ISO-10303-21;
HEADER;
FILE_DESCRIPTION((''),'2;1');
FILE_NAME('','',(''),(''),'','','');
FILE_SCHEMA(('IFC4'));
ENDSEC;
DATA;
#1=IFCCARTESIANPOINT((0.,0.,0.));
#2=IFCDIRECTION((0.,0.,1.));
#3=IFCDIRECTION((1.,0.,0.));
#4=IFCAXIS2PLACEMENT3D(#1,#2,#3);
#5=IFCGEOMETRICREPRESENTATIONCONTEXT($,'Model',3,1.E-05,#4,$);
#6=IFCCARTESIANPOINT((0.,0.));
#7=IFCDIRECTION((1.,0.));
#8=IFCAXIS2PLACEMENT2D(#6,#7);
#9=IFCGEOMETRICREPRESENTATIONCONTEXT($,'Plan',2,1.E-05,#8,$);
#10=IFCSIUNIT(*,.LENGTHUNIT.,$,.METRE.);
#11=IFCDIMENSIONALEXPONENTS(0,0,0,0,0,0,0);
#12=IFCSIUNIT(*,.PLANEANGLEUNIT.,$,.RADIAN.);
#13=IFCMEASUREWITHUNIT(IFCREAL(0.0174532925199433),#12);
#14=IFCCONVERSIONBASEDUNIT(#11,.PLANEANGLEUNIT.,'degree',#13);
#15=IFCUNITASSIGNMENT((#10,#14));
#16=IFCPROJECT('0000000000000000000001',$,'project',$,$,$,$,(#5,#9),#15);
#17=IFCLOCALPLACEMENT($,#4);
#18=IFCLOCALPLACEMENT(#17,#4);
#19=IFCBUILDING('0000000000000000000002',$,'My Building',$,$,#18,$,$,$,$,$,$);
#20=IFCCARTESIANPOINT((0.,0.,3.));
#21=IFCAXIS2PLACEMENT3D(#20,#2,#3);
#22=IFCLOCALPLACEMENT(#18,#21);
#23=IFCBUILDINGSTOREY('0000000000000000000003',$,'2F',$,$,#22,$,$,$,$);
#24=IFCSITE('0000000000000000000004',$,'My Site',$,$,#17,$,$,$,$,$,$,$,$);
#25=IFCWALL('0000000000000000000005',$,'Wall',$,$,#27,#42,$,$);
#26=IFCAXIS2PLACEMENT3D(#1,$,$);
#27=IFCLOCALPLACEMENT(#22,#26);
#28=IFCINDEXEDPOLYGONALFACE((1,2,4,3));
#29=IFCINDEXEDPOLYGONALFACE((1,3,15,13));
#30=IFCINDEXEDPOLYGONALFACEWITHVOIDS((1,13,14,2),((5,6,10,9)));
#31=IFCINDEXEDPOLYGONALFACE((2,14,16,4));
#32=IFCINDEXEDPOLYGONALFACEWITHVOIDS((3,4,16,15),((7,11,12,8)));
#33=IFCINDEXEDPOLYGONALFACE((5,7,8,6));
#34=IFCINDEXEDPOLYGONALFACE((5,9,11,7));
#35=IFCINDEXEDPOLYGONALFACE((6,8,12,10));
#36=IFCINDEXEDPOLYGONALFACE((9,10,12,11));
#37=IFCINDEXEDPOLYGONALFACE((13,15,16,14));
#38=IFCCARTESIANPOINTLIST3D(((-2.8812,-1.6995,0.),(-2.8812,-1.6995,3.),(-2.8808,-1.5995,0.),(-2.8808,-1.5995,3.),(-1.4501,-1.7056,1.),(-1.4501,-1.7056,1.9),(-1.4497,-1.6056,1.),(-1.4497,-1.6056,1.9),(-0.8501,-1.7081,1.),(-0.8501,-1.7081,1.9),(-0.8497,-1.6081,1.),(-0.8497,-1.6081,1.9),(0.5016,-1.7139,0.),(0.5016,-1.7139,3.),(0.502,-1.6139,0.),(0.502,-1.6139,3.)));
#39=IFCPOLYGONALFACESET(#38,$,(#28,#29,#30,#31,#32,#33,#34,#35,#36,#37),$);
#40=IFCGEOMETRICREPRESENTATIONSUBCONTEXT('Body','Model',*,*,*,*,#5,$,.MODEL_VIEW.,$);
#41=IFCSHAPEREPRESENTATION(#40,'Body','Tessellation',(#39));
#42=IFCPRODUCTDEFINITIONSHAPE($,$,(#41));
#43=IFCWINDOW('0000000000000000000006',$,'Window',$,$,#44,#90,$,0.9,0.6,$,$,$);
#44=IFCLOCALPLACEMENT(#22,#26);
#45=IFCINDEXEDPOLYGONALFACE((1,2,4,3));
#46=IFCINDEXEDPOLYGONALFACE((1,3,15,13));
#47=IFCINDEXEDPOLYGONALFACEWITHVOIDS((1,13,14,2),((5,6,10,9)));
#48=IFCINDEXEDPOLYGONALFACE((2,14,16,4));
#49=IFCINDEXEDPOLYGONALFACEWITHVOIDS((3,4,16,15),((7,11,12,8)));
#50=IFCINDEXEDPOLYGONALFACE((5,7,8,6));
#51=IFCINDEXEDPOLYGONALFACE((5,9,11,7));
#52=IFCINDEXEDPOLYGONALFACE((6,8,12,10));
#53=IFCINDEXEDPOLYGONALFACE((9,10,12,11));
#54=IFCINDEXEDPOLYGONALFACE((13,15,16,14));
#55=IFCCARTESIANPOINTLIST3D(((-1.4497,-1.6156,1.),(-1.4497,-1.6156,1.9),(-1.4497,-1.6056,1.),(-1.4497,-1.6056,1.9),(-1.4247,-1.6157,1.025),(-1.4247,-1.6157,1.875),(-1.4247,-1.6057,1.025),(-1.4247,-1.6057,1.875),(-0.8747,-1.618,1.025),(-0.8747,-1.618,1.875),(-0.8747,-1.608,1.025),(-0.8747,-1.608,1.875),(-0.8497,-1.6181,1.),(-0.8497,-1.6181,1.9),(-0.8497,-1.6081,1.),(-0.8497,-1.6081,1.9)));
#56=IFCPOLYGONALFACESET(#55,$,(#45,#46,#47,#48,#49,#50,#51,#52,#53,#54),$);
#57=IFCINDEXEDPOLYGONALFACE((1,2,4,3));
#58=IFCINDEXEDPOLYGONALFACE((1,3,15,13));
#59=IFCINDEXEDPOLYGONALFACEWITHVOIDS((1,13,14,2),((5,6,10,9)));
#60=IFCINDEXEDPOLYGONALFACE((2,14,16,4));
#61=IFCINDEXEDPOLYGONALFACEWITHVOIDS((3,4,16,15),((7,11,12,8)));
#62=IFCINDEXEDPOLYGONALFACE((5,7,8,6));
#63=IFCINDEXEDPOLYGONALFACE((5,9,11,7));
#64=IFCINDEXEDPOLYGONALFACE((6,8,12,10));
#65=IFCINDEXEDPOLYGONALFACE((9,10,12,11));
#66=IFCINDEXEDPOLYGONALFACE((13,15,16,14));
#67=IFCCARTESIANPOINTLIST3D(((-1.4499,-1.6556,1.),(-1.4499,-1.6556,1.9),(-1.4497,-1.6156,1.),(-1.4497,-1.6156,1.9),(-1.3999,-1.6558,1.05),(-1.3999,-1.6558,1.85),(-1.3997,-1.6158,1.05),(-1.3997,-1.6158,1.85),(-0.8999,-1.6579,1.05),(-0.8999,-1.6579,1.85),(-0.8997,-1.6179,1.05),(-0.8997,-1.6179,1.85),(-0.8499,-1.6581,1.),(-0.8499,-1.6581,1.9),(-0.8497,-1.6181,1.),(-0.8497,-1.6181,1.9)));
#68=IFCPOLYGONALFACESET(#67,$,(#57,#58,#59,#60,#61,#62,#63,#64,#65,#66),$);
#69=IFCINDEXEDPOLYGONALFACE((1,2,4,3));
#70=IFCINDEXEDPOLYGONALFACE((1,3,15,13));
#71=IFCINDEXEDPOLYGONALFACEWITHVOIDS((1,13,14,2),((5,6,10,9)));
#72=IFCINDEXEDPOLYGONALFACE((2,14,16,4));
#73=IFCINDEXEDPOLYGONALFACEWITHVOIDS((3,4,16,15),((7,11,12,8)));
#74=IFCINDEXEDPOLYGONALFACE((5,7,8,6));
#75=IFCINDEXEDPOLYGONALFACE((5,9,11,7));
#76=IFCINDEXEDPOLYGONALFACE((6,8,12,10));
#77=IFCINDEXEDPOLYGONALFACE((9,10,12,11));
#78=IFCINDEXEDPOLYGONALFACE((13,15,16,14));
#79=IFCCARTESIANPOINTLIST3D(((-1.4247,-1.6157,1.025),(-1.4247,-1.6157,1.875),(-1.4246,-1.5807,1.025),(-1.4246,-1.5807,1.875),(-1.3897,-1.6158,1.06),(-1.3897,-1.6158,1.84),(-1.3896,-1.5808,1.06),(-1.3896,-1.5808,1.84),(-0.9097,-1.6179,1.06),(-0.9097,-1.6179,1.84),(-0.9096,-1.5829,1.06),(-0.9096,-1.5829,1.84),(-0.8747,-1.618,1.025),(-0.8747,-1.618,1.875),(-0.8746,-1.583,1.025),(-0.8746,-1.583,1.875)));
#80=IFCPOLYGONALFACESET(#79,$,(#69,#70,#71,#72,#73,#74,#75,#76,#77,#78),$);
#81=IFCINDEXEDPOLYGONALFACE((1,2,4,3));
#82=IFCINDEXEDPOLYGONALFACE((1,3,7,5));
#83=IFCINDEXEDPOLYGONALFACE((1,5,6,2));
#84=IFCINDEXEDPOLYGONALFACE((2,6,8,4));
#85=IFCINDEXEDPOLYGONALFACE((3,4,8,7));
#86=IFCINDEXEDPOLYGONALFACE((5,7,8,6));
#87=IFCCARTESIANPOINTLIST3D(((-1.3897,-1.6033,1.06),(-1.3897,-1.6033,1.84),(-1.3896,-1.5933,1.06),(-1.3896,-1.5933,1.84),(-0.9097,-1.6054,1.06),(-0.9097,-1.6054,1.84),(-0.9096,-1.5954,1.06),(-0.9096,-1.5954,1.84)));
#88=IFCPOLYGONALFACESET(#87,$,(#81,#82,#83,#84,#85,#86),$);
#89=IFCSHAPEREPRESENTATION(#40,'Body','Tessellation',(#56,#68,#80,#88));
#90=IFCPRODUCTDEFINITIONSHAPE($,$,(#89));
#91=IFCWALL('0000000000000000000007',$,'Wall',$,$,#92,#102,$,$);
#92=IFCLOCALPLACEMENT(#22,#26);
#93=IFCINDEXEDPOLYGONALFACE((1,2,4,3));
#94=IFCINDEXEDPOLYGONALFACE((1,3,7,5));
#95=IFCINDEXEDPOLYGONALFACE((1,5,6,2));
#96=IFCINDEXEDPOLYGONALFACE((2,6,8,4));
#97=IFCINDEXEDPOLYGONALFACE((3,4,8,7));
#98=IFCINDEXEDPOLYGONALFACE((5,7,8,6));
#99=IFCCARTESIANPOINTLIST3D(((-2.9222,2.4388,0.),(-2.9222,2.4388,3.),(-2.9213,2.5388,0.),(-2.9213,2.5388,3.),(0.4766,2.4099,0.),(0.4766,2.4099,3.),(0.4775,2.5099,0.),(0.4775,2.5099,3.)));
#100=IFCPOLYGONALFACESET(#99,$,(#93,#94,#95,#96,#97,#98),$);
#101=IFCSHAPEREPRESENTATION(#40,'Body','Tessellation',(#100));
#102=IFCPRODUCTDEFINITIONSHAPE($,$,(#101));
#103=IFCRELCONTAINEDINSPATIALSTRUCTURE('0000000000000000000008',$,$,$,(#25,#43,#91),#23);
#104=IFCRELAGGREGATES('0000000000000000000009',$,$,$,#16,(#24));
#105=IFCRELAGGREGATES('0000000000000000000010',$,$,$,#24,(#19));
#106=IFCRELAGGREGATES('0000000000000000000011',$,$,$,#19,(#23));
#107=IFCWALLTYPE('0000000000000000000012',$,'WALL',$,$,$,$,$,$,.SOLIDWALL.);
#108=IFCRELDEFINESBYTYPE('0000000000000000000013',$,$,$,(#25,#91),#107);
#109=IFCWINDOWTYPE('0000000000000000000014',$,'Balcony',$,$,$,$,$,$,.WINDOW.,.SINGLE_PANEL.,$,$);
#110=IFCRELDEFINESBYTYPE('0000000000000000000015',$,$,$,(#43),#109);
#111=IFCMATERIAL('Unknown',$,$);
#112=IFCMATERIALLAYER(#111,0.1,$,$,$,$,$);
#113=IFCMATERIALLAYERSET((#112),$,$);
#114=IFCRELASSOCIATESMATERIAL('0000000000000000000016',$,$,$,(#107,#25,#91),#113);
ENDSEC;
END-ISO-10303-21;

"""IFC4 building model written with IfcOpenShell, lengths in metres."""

from ifc_helpers import new_model, entity, si_unit, converted_unit, frame, origin_with_axes, origin_2d_with_axis, place, context, subcontext, project, spatial, line, indexed_curve, outline, extrude, shape, source, transform, mapped, material, layer, layer_set, layer_usage, type_object, type_shapes, element, fill, save


model = new_model("IFC4")

# Units and contexts
model_context = context("Model", 3, precision=1e-05, world=origin_with_axes())
plan_context = context("Plan", 2, precision=1e-05, world=origin_2d_with_axis())
body_context_1 = subcontext(model_context, "Body", "Model", "MODEL_VIEW")
body_context_2 = subcontext(plan_context, "Body", "Plan", "PLAN_VIEW")
ifc_project = project(units=[si_unit("LENGTHUNIT", "METRE"), converted_unit("PLANEANGLEUNIT", "degree", entity("IfcReal", 0.0174532925199433), si_unit("PLANEANGLEUNIT", "RADIAN"), dimensions=[0, 0, 0, 0, 0, 0, 0])], contexts=[model_context, plan_context])

# Site, building, storey
site_placement = place(None, origin_with_axes())
site = spatial("IfcSite", under=ifc_project, at=site_placement, Name="My Site")
building_placement = place(site_placement, origin_with_axes())
building = spatial("IfcBuilding", under=site, at=building_placement, Name="My Building")
storey_placement = place(building_placement, frame((0.0, 0.0, 3.0), z_axis=(0.0, 0.0, 1.0), x_axis=(1.0, 0.0, 0.0)))
storey = spatial("IfcBuildingStorey", under=building, at=storey_placement, Name="2F")

# Wall, opening, window
ifc_material = material(Name="Unknown")
ifc_layer = layer(ifc_material, 0.1)
ifc_layer_set = layer_set([ifc_layer])
ifc_layer_usage_1 = layer_usage(ifc_layer_set, "AXIS2", "POSITIVE", 0.0)
wall_type = type_object("IfcWallType", Name="WALL", PredefinedType="SOLIDWALL", material=ifc_layer_set)
wall_1_placement = place(storey_placement, frame((-2.8812, -1.6995, 0.0), z_axis=(0.0, 0.0, 1.0), x_axis=(0.999991, -0.004277, 0.0)))
wall_1 = element("IfcWall", 1, at=wall_1_placement, inside=storey, type_object=wall_type, material=ifc_layer_usage_1, Name="Wall", context=body_context_1, shape_type="SweptSolid", body=[
    extrude(outline(indexed_curve([(0.0, 0.0), (0.0, 0.1), (3.3828, 0.1), (3.3828, 0.0)], segments=[line(1, 2, 3, 4, 1)])), origin_with_axes(), (0.0, 0.0, 1.0), 3.0),
])
shared_shape_1 = source(origin_with_axes(), body_context_1, "Body", "SweptSolid", [
    extrude(outline(indexed_curve([(0.0, 0.0), (0.6, 0.0), (0.6, 0.9), (0.0, 0.9)], segments=[line(1, 2, 3, 4, 1)])), frame((0.0, -0.6, 0.0), z_axis=(0.0, -1.0, 0.0), x_axis=(1.0, 0.0, 0.0)), (0.0, 0.0, -1.0), 1.2),
])
opening_1_placement = place(wall_1_placement, frame((1.4311, 0.0, 1.0), z_axis=(0.0, 0.0, 1.0), x_axis=(1.0, 0.0, 0.0)))
opening_1 = element("IfcOpeningElement", 2, at=opening_1_placement, cuts=wall_1, PredefinedType="OPENING", context=body_context_1, shape_type="MappedRepresentation", body=[
    mapped(shared_shape_1, transform((0.0, 0.0, 0.0), x_axis=(1.0, 0.0, 0.0), y_axis=(0.0, 1.0, 0.0), z_axis=(0.0, 0.0, 1.0), scale=1.0)),
])
window_type = type_object("IfcWindowType", Name="Balcony", PartitioningType="SINGLE_PANEL", PredefinedType="WINDOW")
shared_shape_2 = source(origin_with_axes(), body_context_1, "Body", "SweptSolid", [
    extrude(outline(indexed_curve([(0.0, 0.0), (0.6, 0.0), (0.6, 0.9), (0.0, 0.9)], segments=[line(1, 2, 3, 4, 1)]), holes=[indexed_curve([(0.025, 0.025), (0.575, 0.025), (0.575, 0.875), (0.025, 0.875)], segments=[line(1, 2, 3, 4, 1)])]), frame((0.0, 0.09, 0.0), z_axis=(0.0, -1.0, 0.0), x_axis=(1.0, 0.0, 0.0)), (0.0, 0.0, -1.0), 0.01),
    extrude(outline(indexed_curve([(0.0, 0.0), (0.6, 0.0), (0.6, 0.9), (0.0, 0.9)], segments=[line(1, 2, 3, 4, 1)]), holes=[indexed_curve([(0.05, 0.05), (0.55, 0.05), (0.55, 0.85), (0.05, 0.85)], segments=[line(1, 2, 3, 4, 1)])]), frame((0.0, 0.05, 0.0), z_axis=(0.0, -1.0, 0.0), x_axis=(1.0, 0.0, 0.0)), (0.0, 0.0, -1.0), 0.04),
    extrude(outline(indexed_curve([(0.0, 0.0), (0.55, 0.0), (0.55, 0.85), (0.0, 0.85)], segments=[line(1, 2, 3, 4, 1)]), holes=[indexed_curve([(0.035, 0.035), (0.515, 0.035), (0.515, 0.815), (0.035, 0.815)], segments=[line(1, 2, 3, 4, 1)])]), frame((0.025, 0.09, 0.025), z_axis=(0.0, -1.0, 0.0), x_axis=(1.0, 0.0, 0.0)), (0.0, 0.0, -1.0), 0.035),
    extrude(outline(indexed_curve([(0.035, 0.035), (0.515, 0.035), (0.515, 0.815), (0.035, 0.815)], segments=[line(1, 2, 3, 4, 1)])), frame((0.025, 0.1025, 0.025), z_axis=(0.0, -1.0, 0.0), x_axis=(1.0, 0.0, 0.0)), (0.0, 0.0, -1.0), 0.01),
])
shared_shape_3 = source(origin_with_axes(), body_context_2, "Body", "Curve2D", [
    entity("IfcIndexedPolyCurve", entity("IfcCartesianPointList2D", [[0.05, 0.05], [0.55, 0.05]])),
    entity("IfcIndexedPolyCurve", entity("IfcCartesianPointList2D", [[0.0, 0.1], [0.025, 0.1], [0.025, 0.09], [0.05, 0.09], [0.05, 0.05], [0.0, 0.05]]), [entity("IfcLineIndex", [1, 2, 3, 4, 5, 6, 1])]),
    entity("IfcIndexedPolyCurve", entity("IfcCartesianPointList2D", [[0.6, 0.1], [0.575, 0.1], [0.575, 0.09], [0.55, 0.09], [0.55, 0.05], [0.6, 0.05]]), [entity("IfcLineIndex", [1, 2, 3, 4, 5, 6, 1])]),
    entity("IfcIndexedPolyCurve", entity("IfcCartesianPointList2D", [[0.025, 0.09], [0.06, 0.09], [0.06, 0.125], [0.025, 0.125]]), [entity("IfcLineIndex", [1, 2, 3, 4, 1])]),
    entity("IfcIndexedPolyCurve", entity("IfcCartesianPointList2D", [[0.575, 0.09], [0.54, 0.09], [0.54, 0.125], [0.575, 0.125]]), [entity("IfcLineIndex", [1, 2, 3, 4, 1])]),
    entity("IfcIndexedPolyCurve", entity("IfcCartesianPointList2D", [[0.06, 0.09], [0.54, 0.09]])),
    entity("IfcIndexedPolyCurve", entity("IfcCartesianPointList2D", [[0.06, 0.125], [0.54, 0.125]])),
    entity("IfcIndexedPolyCurve", entity("IfcCartesianPointList2D", [[0.06, 0.1075], [0.54, 0.1075]])),
])
type_shapes(window_type, [shared_shape_2, shared_shape_3])
window_placement = place(opening_1_placement, frame((0.0, 0.0, 0.0), z_axis=(0.0, 0.0, 1.0), x_axis=(1.0, 0.0, 0.0)))
window = element("IfcWindow", 3, at=window_placement, inside=storey, type_object=window_type, Name="Window", OverallHeight=0.9, OverallWidth=0.6, shapes=[
    shape(body_context_1, "Body", "MappedRepresentation", [mapped(shared_shape_2, transform((0.0, 0.0, 0.0), x_axis=(1.0, 0.0, 0.0), y_axis=(0.0, 1.0, 0.0), z_axis=(0.0, 0.0, 1.0), scale=1.0))]),
    shape(body_context_2, "Body", "MappedRepresentation", [mapped(shared_shape_3, transform((0.0, 0.0, 0.0), x_axis=(1.0, 0.0, 0.0), y_axis=(0.0, 1.0, 0.0), z_axis=(0.0, 0.0, 1.0), scale=1.0))]),
])
fill(opening_1, window)

# Wall
ifc_layer_usage_2 = layer_usage(ifc_layer_set, "AXIS2", "POSITIVE", 0.0)
wall_2_placement = place(storey_placement, frame((-2.9222, 2.4388, 0.0), z_axis=(0.0, 0.0, 1.0), x_axis=(0.999964, -0.008491, 0.0)))
element("IfcWall", 4, at=wall_2_placement, inside=storey, type_object=wall_type, material=ifc_layer_usage_2, Name="Wall", context=body_context_1, shape_type="SweptSolid", body=[
    extrude(outline(indexed_curve([(0.0, 0.0), (0.0, 0.1), (3.3989, 0.1), (3.3989, 0.0)], segments=[line(1, 2, 3, 4, 1)])), origin_with_axes(), (0.0, 0.0, 1.0), 3.0),
])

save(model, "model.ifc")
